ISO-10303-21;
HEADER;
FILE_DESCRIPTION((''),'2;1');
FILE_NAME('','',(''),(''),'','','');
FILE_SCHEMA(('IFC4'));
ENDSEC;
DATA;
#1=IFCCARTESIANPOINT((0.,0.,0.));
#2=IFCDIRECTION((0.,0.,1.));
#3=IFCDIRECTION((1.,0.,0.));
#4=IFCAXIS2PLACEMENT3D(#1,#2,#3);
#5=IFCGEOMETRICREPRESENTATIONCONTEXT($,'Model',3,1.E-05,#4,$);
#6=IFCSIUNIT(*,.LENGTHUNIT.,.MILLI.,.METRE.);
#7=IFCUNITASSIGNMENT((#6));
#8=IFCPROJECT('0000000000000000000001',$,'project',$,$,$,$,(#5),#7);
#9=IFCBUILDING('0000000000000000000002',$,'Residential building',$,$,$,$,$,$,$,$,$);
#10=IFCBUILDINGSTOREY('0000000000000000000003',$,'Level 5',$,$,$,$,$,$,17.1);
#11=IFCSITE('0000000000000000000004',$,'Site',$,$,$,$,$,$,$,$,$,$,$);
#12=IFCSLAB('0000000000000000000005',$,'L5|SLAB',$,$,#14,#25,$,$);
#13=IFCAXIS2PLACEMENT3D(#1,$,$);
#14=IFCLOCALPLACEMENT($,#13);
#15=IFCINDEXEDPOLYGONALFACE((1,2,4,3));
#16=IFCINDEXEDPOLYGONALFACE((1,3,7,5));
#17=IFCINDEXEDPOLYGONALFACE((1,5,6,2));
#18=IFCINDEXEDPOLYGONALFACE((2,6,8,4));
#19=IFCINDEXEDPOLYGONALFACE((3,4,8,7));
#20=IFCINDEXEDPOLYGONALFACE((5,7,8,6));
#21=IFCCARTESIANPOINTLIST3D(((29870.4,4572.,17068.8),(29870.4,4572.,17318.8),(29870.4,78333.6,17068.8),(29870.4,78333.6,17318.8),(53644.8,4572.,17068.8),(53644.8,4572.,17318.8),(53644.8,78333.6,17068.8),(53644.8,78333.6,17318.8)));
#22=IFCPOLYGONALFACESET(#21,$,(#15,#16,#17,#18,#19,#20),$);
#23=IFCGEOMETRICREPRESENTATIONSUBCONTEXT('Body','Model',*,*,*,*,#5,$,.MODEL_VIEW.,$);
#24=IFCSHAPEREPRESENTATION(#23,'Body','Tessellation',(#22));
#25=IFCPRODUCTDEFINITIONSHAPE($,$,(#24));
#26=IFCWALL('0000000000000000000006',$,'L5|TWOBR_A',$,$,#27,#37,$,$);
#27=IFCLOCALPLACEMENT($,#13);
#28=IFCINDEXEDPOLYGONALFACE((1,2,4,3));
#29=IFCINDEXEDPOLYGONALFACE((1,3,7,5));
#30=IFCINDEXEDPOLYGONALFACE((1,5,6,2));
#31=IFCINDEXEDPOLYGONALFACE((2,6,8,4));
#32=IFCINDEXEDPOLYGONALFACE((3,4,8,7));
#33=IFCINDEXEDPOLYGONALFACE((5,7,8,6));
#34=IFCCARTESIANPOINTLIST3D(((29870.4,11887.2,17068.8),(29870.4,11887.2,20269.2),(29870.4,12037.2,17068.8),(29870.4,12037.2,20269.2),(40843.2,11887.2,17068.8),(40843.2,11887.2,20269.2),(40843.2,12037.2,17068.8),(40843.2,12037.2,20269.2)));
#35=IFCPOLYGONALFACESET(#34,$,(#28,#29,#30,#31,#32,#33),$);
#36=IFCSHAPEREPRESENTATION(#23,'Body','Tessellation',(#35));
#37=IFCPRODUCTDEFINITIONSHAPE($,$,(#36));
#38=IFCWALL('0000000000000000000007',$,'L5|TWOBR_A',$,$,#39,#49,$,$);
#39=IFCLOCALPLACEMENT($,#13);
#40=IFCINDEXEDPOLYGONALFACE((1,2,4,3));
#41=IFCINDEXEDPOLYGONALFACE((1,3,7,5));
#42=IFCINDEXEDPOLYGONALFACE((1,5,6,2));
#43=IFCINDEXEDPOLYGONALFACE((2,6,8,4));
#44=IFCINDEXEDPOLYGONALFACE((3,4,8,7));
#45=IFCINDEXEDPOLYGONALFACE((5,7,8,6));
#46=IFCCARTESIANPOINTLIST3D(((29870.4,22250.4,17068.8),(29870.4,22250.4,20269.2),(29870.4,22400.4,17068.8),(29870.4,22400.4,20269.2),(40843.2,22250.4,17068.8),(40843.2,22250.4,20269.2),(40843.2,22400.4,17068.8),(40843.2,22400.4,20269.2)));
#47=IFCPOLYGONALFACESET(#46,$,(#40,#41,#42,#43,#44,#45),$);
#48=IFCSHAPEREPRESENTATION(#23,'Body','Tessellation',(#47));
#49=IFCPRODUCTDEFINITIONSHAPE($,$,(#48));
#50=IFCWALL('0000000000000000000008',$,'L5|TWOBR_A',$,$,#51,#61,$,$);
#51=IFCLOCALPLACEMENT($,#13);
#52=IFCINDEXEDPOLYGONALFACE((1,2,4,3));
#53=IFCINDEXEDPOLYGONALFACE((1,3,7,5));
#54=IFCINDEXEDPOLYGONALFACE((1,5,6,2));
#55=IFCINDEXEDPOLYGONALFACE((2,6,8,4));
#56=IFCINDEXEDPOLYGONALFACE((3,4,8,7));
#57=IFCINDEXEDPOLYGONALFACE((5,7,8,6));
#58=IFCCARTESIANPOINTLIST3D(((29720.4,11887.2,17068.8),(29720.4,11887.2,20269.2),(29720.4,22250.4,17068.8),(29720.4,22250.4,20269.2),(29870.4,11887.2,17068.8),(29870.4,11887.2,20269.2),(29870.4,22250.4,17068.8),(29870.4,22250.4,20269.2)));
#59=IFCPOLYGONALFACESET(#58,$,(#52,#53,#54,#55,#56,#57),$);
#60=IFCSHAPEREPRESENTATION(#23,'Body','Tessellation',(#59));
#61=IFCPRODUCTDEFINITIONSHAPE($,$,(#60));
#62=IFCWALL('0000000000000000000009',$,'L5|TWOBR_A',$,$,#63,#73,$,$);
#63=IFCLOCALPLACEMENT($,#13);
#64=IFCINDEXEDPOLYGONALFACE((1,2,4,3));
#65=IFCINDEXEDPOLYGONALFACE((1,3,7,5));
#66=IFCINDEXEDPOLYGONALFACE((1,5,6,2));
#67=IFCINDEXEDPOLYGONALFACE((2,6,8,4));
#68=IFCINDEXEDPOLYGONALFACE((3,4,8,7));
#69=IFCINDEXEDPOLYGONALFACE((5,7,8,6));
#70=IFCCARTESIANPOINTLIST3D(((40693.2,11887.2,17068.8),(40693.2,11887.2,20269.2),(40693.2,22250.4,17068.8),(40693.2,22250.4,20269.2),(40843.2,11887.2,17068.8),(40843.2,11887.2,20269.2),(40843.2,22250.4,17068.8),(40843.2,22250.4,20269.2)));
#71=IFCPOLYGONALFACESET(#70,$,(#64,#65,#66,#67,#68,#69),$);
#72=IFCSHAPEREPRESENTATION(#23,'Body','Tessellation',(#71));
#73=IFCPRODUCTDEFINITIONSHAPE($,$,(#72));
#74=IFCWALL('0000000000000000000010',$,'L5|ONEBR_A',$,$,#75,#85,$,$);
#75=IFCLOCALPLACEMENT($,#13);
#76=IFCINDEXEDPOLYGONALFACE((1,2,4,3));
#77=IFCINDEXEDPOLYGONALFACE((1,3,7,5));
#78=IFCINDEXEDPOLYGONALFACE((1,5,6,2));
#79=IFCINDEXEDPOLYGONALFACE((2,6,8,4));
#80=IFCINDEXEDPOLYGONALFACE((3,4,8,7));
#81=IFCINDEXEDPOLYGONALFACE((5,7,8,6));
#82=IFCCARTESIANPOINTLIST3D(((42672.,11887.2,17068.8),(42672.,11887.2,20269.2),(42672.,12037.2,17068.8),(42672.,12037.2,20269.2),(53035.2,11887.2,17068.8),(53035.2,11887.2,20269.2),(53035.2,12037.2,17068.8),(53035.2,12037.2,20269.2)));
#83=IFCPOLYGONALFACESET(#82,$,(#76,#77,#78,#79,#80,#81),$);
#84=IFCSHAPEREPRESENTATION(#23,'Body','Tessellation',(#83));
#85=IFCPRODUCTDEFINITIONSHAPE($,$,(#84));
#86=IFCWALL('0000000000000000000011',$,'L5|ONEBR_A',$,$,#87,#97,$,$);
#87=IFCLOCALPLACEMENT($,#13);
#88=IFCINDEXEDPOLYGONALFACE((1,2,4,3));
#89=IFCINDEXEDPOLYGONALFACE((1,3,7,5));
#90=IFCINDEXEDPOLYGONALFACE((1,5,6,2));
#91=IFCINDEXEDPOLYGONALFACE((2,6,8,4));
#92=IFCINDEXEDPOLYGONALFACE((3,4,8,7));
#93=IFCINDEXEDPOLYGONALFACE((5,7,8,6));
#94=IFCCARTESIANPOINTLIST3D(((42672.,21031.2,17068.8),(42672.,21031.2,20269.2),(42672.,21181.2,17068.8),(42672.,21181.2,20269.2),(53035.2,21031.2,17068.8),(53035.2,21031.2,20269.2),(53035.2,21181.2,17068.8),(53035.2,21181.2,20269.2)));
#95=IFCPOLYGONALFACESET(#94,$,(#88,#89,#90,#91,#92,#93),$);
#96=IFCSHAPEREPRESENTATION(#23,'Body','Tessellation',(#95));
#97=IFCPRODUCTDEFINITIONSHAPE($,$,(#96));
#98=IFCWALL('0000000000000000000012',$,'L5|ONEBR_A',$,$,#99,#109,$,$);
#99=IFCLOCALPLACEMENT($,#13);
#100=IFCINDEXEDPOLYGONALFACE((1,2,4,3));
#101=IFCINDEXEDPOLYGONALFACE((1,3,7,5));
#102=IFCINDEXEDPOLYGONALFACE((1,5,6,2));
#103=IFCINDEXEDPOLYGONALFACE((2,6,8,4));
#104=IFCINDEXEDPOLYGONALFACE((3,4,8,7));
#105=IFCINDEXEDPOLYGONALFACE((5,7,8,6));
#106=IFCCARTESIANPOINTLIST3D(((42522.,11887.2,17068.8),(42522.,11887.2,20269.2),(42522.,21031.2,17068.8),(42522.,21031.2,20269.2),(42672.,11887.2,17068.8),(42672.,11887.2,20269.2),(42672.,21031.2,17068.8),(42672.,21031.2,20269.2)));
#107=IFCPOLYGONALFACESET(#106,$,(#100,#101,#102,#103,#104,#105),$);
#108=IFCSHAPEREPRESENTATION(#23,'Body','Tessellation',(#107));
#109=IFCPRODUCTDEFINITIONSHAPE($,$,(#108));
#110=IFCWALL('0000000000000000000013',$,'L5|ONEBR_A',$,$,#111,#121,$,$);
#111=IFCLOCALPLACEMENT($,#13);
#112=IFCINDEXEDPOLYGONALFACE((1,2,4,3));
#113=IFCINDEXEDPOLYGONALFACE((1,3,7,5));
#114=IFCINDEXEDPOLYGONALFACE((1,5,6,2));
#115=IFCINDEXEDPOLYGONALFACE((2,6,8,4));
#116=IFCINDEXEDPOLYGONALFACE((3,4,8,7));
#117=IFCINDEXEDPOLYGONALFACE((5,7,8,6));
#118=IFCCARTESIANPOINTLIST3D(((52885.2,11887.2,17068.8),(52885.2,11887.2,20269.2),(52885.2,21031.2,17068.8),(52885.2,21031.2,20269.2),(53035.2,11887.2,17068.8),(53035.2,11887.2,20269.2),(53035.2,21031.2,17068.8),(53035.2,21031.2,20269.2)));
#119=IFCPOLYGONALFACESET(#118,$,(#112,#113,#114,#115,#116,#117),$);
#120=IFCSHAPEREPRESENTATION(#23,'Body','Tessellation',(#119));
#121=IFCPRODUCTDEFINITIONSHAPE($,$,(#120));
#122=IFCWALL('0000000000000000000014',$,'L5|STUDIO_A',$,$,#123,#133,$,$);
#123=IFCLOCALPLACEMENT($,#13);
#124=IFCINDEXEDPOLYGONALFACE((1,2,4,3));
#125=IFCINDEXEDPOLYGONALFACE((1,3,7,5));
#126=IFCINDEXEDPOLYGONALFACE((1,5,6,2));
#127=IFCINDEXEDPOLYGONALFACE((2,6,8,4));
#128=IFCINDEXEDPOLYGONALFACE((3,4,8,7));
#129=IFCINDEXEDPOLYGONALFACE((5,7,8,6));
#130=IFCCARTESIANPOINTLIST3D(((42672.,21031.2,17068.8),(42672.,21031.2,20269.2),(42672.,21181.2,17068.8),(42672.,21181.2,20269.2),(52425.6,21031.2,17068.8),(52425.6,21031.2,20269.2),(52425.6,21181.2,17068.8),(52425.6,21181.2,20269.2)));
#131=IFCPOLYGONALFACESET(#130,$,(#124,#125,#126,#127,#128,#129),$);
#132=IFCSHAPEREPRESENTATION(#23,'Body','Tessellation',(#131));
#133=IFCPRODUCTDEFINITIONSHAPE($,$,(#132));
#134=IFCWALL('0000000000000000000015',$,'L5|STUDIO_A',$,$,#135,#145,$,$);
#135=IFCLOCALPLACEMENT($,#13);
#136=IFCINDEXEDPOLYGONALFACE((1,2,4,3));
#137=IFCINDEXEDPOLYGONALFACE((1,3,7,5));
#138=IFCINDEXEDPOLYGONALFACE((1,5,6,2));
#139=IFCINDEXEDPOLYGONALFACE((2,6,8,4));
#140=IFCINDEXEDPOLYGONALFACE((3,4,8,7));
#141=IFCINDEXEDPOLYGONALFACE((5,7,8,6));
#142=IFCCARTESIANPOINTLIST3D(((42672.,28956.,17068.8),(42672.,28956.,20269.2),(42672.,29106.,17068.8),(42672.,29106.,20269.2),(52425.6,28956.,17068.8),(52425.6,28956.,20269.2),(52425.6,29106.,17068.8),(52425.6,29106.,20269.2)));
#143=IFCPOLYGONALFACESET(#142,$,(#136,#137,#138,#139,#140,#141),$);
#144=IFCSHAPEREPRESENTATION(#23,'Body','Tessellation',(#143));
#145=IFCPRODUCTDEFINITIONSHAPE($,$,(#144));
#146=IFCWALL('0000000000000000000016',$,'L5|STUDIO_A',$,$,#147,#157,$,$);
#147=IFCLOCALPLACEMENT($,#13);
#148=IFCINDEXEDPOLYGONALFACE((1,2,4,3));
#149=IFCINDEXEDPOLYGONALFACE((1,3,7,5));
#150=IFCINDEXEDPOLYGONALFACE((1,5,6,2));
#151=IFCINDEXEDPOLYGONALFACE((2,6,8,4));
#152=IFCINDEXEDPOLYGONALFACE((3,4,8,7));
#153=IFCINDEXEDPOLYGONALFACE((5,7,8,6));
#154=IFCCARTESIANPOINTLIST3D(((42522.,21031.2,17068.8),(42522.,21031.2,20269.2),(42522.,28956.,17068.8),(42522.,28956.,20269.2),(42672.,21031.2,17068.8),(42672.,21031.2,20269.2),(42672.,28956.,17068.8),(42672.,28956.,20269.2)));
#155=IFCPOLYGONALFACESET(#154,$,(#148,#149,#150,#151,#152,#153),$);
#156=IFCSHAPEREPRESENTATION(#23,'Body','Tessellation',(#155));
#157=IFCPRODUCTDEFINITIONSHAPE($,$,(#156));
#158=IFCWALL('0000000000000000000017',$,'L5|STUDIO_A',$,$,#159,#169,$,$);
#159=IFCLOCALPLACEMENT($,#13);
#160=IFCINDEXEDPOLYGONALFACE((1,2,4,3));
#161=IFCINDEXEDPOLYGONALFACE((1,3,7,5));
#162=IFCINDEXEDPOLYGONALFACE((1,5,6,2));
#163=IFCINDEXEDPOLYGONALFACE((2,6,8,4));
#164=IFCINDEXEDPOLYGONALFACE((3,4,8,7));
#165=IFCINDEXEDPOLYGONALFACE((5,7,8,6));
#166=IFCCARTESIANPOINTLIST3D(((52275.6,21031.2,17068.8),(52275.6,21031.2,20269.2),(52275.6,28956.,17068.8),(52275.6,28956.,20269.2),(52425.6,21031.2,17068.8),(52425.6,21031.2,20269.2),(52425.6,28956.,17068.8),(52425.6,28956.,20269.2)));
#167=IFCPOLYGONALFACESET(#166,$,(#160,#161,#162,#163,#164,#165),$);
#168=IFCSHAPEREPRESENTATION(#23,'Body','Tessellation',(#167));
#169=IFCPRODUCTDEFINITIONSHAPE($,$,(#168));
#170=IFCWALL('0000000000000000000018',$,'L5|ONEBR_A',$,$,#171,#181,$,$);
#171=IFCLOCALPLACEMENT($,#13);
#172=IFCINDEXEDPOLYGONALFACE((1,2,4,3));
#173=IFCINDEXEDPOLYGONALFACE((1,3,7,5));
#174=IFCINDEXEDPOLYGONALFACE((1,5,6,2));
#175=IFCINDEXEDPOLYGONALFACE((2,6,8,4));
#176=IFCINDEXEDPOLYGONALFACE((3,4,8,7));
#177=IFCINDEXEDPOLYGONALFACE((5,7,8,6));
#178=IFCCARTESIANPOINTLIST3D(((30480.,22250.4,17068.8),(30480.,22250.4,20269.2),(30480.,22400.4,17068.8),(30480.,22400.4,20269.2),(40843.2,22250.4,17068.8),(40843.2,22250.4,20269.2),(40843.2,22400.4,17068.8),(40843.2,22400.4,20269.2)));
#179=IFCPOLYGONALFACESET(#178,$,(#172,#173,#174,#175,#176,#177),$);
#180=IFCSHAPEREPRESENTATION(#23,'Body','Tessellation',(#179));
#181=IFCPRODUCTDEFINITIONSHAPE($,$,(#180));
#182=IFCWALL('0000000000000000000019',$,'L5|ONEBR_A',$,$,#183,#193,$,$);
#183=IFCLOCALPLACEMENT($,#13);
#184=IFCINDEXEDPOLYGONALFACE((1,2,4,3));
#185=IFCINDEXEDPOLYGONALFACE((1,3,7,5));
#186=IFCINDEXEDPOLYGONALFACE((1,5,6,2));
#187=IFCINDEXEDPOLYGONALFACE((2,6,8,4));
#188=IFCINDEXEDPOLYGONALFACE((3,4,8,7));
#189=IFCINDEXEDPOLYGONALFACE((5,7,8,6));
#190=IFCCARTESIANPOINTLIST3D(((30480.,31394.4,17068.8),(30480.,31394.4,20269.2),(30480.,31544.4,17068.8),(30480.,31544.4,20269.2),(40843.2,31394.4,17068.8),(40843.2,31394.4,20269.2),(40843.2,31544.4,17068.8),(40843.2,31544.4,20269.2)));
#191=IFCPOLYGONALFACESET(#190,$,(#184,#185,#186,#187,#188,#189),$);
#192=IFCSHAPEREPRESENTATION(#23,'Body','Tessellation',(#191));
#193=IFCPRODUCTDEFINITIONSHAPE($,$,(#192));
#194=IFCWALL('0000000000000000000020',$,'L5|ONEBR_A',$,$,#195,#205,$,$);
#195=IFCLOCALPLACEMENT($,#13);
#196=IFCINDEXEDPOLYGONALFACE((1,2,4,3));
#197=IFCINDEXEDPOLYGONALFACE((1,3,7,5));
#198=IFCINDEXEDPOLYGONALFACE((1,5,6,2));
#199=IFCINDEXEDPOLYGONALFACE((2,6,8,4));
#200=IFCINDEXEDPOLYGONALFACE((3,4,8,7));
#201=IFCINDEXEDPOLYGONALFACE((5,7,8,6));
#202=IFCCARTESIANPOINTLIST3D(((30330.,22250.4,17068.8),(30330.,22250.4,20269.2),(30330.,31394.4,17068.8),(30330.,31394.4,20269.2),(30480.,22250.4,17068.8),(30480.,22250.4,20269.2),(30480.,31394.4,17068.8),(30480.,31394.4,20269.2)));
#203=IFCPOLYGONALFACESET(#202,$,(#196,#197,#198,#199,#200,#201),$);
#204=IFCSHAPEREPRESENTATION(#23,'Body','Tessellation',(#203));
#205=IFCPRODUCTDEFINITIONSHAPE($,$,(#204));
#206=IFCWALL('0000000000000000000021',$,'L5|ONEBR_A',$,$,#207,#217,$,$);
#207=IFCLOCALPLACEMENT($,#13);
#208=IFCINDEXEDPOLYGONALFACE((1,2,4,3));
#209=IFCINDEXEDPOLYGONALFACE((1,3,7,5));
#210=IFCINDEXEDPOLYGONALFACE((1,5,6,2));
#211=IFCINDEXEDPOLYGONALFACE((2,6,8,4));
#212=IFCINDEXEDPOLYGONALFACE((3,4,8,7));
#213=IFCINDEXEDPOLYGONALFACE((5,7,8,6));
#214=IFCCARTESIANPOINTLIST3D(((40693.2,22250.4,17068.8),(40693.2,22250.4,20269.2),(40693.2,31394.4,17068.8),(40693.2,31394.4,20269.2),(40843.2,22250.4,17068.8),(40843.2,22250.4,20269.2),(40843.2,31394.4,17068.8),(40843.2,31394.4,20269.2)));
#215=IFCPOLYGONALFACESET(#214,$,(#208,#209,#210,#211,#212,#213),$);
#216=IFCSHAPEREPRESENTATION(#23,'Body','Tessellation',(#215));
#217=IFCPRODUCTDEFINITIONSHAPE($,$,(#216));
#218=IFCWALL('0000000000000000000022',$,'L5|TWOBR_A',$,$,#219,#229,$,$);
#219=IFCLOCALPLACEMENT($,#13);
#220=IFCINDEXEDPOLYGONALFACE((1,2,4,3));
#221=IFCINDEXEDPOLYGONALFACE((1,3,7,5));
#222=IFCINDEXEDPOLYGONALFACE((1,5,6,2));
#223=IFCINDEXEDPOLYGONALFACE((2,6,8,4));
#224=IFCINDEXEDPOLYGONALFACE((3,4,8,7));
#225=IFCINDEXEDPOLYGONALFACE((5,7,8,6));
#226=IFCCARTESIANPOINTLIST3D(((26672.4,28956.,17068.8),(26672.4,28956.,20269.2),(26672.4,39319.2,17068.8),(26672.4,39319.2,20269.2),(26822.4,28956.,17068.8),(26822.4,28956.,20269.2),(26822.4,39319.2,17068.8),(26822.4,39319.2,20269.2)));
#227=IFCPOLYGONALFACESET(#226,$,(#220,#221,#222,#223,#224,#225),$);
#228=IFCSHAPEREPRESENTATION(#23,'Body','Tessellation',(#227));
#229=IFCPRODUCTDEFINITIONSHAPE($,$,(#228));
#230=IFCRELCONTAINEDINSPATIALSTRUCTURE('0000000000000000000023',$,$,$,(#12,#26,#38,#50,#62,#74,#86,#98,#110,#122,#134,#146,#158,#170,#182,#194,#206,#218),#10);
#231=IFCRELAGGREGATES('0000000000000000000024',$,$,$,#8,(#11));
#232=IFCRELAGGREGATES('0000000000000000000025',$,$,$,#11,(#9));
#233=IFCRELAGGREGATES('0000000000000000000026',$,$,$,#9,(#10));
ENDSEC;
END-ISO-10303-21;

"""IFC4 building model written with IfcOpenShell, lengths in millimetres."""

from ifc_helpers import new_model, si_unit, frame, origin_with_axes, place, context, subcontext, project, spatial, indexed_curve, outline, extrude, element, save


model = new_model("IFC4")

# Units and contexts
model_context = context("Model", 3, precision=1e-05, world=origin_with_axes())
body_context = subcontext(model_context, "Body", "Model", "MODEL_VIEW")
ifc_project = project(units=[si_unit("LENGTHUNIT", "METRE", prefix="MILLI")], contexts=[model_context])

# Site, building, storey
site = spatial("IfcSite", under=ifc_project, Name="Site")
building = spatial("IfcBuilding", under=site, Name="Residential building")
storey = spatial("IfcBuildingStorey", under=building, Name="Level 5", Elevation=17.1)

# Slab
slab_placement = place(None, frame((29870.4, 4572.0, 17068.8), z_axis=(0.0, 0.0, 1.0), x_axis=(1.0, 0.0, 0.0)))
element("IfcSlab", 1, at=slab_placement, inside=storey, Name="L5|SLAB", context=body_context, shape_type="SweptSolid", body=[
    extrude(outline(indexed_curve([(0.0, 0.0), (23774.4, 0.0), (23774.4, 73761.6), (0.0, 73761.6), (0.0, 0.0)])), None, (0.0, 0.0, 1.0), 250.0),
])

# Walls
for number, where, z_axis, x_axis, name in (
    (2, (29870.4, 11887.2, 17068.8), (0.0, 0.0, 1.0), (1.0, 0.0, 0.0), "L5|TWOBR_A"),
    (3, (29870.4, 22250.4, 17068.8), (0.0, 0.0, 1.0), (1.0, 0.0, 0.0), "L5|TWOBR_A"),
):
    element("IfcWall", number, at=place(None, frame(where, z_axis=z_axis, x_axis=x_axis)), inside=storey, Name=name, context=body_context, shape_type="SweptSolid", body=[
        extrude(outline(indexed_curve([(0.0, 0.0), (0.0, 150.0), (10972.8, 150.0), (10972.8, 0.0), (0.0, 0.0)], self_intersect=False)), origin_with_axes(), (0.0, 0.0, 1.0), 3200.4),
    ])
for number, where, z_axis, x_axis, name in (
    (4, (29870.4, 11887.2, 17068.8), (0.0, 0.0, 1.0), (0.0, 1.0, 0.0), "L5|TWOBR_A"),
    (5, (40843.2, 11887.2, 17068.8), (0.0, 0.0, 1.0), (0.0, 1.0, 0.0), "L5|TWOBR_A"),
    (6, (42672.0, 11887.2, 17068.8), (0.0, 0.0, 1.0), (1.0, 0.0, 0.0), "L5|ONEBR_A"),
    (7, (42672.0, 21031.2, 17068.8), (0.0, 0.0, 1.0), (1.0, 0.0, 0.0), "L5|ONEBR_A"),
):
    element("IfcWall", number, at=place(None, frame(where, z_axis=z_axis, x_axis=x_axis)), inside=storey, Name=name, context=body_context, shape_type="SweptSolid", body=[
        extrude(outline(indexed_curve([(0.0, 0.0), (0.0, 150.0), (10363.2, 150.0), (10363.2, 0.0), (0.0, 0.0)], self_intersect=False)), origin_with_axes(), (0.0, 0.0, 1.0), 3200.4),
    ])
for number, where, z_axis, x_axis, name in (
    (8, (42672.0, 11887.2, 17068.8), (0.0, 0.0, 1.0), (0.0, 1.0, 0.0), "L5|ONEBR_A"),
    (9, (53035.2, 11887.2, 17068.8), (0.0, 0.0, 1.0), (0.0, 1.0, 0.0), "L5|ONEBR_A"),
):
    element("IfcWall", number, at=place(None, frame(where, z_axis=z_axis, x_axis=x_axis)), inside=storey, Name=name, context=body_context, shape_type="SweptSolid", body=[
        extrude(outline(indexed_curve([(0.0, 0.0), (0.0, 150.0), (9144.0, 150.0), (9144.0, 0.0), (0.0, 0.0)], self_intersect=False)), origin_with_axes(), (0.0, 0.0, 1.0), 3200.4),
    ])
for number, where, z_axis, x_axis, name in (
    (10, (42672.0, 21031.2, 17068.8), (0.0, 0.0, 1.0), (1.0, 0.0, 0.0), "L5|STUDIO_A"),
    (11, (42672.0, 28956.0, 17068.8), (0.0, 0.0, 1.0), (1.0, 0.0, 0.0), "L5|STUDIO_A"),
):
    element("IfcWall", number, at=place(None, frame(where, z_axis=z_axis, x_axis=x_axis)), inside=storey, Name=name, context=body_context, shape_type="SweptSolid", body=[
        extrude(outline(indexed_curve([(0.0, 0.0), (0.0, 150.0), (9753.6, 150.0), (9753.6, 0.0), (0.0, 0.0)], self_intersect=False)), origin_with_axes(), (0.0, 0.0, 1.0), 3200.4),
    ])
for number, where, z_axis, x_axis, name in (
    (12, (42672.0, 21031.2, 17068.8), (0.0, 0.0, 1.0), (0.0, 1.0, 0.0), "L5|STUDIO_A"),
    (13, (52425.6, 21031.2, 17068.8), (0.0, 0.0, 1.0), (0.0, 1.0, 0.0), "L5|STUDIO_A"),
):
    element("IfcWall", number, at=place(None, frame(where, z_axis=z_axis, x_axis=x_axis)), inside=storey, Name=name, context=body_context, shape_type="SweptSolid", body=[
        extrude(outline(indexed_curve([(0.0, 0.0), (0.0, 150.0), (7924.8, 150.0), (7924.8, 0.0), (0.0, 0.0)], self_intersect=False)), origin_with_axes(), (0.0, 0.0, 1.0), 3200.4),
    ])
for number, where, z_axis, x_axis, name in (
    (14, (30480.0, 22250.4, 17068.8), (0.0, 0.0, 1.0), (1.0, 0.0, 0.0), "L5|ONEBR_A"),
    (15, (30480.0, 31394.4, 17068.8), (0.0, 0.0, 1.0), (1.0, 0.0, 0.0), "L5|ONEBR_A"),
):
    element("IfcWall", number, at=place(None, frame(where, z_axis=z_axis, x_axis=x_axis)), inside=storey, Name=name, context=body_context, shape_type="SweptSolid", body=[
        extrude(outline(indexed_curve([(0.0, 0.0), (0.0, 150.0), (10363.2, 150.0), (10363.2, 0.0), (0.0, 0.0)], self_intersect=False)), origin_with_axes(), (0.0, 0.0, 1.0), 3200.4),
    ])
for number, where, z_axis, x_axis, name in (
    (16, (30480.0, 22250.4, 17068.8), (0.0, 0.0, 1.0), (0.0, 1.0, 0.0), "L5|ONEBR_A"),
    (17, (40843.2, 22250.4, 17068.8), (0.0, 0.0, 1.0), (0.0, 1.0, 0.0), "L5|ONEBR_A"),
):
    element("IfcWall", number, at=place(None, frame(where, z_axis=z_axis, x_axis=x_axis)), inside=storey, Name=name, context=body_context, shape_type="SweptSolid", body=[
        extrude(outline(indexed_curve([(0.0, 0.0), (0.0, 150.0), (9144.0, 150.0), (9144.0, 0.0), (0.0, 0.0)], self_intersect=False)), origin_with_axes(), (0.0, 0.0, 1.0), 3200.4),
    ])
for number, where, z_axis, x_axis, name in (
    (18, (26822.4, 28956.0, 17068.8), (0.0, 0.0, 1.0), (0.0, 1.0, 0.0), "L5|TWOBR_A"),
):
    element("IfcWall", number, at=place(None, frame(where, z_axis=z_axis, x_axis=x_axis)), inside=storey, Name=name, context=body_context, shape_type="SweptSolid", body=[
        extrude(outline(indexed_curve([(0.0, 0.0), (0.0, 150.0), (10363.2, 150.0), (10363.2, 0.0), (0.0, 0.0)], self_intersect=False)), origin_with_axes(), (0.0, 0.0, 1.0), 3200.4),
    ])

save(model, "model.ifc")
